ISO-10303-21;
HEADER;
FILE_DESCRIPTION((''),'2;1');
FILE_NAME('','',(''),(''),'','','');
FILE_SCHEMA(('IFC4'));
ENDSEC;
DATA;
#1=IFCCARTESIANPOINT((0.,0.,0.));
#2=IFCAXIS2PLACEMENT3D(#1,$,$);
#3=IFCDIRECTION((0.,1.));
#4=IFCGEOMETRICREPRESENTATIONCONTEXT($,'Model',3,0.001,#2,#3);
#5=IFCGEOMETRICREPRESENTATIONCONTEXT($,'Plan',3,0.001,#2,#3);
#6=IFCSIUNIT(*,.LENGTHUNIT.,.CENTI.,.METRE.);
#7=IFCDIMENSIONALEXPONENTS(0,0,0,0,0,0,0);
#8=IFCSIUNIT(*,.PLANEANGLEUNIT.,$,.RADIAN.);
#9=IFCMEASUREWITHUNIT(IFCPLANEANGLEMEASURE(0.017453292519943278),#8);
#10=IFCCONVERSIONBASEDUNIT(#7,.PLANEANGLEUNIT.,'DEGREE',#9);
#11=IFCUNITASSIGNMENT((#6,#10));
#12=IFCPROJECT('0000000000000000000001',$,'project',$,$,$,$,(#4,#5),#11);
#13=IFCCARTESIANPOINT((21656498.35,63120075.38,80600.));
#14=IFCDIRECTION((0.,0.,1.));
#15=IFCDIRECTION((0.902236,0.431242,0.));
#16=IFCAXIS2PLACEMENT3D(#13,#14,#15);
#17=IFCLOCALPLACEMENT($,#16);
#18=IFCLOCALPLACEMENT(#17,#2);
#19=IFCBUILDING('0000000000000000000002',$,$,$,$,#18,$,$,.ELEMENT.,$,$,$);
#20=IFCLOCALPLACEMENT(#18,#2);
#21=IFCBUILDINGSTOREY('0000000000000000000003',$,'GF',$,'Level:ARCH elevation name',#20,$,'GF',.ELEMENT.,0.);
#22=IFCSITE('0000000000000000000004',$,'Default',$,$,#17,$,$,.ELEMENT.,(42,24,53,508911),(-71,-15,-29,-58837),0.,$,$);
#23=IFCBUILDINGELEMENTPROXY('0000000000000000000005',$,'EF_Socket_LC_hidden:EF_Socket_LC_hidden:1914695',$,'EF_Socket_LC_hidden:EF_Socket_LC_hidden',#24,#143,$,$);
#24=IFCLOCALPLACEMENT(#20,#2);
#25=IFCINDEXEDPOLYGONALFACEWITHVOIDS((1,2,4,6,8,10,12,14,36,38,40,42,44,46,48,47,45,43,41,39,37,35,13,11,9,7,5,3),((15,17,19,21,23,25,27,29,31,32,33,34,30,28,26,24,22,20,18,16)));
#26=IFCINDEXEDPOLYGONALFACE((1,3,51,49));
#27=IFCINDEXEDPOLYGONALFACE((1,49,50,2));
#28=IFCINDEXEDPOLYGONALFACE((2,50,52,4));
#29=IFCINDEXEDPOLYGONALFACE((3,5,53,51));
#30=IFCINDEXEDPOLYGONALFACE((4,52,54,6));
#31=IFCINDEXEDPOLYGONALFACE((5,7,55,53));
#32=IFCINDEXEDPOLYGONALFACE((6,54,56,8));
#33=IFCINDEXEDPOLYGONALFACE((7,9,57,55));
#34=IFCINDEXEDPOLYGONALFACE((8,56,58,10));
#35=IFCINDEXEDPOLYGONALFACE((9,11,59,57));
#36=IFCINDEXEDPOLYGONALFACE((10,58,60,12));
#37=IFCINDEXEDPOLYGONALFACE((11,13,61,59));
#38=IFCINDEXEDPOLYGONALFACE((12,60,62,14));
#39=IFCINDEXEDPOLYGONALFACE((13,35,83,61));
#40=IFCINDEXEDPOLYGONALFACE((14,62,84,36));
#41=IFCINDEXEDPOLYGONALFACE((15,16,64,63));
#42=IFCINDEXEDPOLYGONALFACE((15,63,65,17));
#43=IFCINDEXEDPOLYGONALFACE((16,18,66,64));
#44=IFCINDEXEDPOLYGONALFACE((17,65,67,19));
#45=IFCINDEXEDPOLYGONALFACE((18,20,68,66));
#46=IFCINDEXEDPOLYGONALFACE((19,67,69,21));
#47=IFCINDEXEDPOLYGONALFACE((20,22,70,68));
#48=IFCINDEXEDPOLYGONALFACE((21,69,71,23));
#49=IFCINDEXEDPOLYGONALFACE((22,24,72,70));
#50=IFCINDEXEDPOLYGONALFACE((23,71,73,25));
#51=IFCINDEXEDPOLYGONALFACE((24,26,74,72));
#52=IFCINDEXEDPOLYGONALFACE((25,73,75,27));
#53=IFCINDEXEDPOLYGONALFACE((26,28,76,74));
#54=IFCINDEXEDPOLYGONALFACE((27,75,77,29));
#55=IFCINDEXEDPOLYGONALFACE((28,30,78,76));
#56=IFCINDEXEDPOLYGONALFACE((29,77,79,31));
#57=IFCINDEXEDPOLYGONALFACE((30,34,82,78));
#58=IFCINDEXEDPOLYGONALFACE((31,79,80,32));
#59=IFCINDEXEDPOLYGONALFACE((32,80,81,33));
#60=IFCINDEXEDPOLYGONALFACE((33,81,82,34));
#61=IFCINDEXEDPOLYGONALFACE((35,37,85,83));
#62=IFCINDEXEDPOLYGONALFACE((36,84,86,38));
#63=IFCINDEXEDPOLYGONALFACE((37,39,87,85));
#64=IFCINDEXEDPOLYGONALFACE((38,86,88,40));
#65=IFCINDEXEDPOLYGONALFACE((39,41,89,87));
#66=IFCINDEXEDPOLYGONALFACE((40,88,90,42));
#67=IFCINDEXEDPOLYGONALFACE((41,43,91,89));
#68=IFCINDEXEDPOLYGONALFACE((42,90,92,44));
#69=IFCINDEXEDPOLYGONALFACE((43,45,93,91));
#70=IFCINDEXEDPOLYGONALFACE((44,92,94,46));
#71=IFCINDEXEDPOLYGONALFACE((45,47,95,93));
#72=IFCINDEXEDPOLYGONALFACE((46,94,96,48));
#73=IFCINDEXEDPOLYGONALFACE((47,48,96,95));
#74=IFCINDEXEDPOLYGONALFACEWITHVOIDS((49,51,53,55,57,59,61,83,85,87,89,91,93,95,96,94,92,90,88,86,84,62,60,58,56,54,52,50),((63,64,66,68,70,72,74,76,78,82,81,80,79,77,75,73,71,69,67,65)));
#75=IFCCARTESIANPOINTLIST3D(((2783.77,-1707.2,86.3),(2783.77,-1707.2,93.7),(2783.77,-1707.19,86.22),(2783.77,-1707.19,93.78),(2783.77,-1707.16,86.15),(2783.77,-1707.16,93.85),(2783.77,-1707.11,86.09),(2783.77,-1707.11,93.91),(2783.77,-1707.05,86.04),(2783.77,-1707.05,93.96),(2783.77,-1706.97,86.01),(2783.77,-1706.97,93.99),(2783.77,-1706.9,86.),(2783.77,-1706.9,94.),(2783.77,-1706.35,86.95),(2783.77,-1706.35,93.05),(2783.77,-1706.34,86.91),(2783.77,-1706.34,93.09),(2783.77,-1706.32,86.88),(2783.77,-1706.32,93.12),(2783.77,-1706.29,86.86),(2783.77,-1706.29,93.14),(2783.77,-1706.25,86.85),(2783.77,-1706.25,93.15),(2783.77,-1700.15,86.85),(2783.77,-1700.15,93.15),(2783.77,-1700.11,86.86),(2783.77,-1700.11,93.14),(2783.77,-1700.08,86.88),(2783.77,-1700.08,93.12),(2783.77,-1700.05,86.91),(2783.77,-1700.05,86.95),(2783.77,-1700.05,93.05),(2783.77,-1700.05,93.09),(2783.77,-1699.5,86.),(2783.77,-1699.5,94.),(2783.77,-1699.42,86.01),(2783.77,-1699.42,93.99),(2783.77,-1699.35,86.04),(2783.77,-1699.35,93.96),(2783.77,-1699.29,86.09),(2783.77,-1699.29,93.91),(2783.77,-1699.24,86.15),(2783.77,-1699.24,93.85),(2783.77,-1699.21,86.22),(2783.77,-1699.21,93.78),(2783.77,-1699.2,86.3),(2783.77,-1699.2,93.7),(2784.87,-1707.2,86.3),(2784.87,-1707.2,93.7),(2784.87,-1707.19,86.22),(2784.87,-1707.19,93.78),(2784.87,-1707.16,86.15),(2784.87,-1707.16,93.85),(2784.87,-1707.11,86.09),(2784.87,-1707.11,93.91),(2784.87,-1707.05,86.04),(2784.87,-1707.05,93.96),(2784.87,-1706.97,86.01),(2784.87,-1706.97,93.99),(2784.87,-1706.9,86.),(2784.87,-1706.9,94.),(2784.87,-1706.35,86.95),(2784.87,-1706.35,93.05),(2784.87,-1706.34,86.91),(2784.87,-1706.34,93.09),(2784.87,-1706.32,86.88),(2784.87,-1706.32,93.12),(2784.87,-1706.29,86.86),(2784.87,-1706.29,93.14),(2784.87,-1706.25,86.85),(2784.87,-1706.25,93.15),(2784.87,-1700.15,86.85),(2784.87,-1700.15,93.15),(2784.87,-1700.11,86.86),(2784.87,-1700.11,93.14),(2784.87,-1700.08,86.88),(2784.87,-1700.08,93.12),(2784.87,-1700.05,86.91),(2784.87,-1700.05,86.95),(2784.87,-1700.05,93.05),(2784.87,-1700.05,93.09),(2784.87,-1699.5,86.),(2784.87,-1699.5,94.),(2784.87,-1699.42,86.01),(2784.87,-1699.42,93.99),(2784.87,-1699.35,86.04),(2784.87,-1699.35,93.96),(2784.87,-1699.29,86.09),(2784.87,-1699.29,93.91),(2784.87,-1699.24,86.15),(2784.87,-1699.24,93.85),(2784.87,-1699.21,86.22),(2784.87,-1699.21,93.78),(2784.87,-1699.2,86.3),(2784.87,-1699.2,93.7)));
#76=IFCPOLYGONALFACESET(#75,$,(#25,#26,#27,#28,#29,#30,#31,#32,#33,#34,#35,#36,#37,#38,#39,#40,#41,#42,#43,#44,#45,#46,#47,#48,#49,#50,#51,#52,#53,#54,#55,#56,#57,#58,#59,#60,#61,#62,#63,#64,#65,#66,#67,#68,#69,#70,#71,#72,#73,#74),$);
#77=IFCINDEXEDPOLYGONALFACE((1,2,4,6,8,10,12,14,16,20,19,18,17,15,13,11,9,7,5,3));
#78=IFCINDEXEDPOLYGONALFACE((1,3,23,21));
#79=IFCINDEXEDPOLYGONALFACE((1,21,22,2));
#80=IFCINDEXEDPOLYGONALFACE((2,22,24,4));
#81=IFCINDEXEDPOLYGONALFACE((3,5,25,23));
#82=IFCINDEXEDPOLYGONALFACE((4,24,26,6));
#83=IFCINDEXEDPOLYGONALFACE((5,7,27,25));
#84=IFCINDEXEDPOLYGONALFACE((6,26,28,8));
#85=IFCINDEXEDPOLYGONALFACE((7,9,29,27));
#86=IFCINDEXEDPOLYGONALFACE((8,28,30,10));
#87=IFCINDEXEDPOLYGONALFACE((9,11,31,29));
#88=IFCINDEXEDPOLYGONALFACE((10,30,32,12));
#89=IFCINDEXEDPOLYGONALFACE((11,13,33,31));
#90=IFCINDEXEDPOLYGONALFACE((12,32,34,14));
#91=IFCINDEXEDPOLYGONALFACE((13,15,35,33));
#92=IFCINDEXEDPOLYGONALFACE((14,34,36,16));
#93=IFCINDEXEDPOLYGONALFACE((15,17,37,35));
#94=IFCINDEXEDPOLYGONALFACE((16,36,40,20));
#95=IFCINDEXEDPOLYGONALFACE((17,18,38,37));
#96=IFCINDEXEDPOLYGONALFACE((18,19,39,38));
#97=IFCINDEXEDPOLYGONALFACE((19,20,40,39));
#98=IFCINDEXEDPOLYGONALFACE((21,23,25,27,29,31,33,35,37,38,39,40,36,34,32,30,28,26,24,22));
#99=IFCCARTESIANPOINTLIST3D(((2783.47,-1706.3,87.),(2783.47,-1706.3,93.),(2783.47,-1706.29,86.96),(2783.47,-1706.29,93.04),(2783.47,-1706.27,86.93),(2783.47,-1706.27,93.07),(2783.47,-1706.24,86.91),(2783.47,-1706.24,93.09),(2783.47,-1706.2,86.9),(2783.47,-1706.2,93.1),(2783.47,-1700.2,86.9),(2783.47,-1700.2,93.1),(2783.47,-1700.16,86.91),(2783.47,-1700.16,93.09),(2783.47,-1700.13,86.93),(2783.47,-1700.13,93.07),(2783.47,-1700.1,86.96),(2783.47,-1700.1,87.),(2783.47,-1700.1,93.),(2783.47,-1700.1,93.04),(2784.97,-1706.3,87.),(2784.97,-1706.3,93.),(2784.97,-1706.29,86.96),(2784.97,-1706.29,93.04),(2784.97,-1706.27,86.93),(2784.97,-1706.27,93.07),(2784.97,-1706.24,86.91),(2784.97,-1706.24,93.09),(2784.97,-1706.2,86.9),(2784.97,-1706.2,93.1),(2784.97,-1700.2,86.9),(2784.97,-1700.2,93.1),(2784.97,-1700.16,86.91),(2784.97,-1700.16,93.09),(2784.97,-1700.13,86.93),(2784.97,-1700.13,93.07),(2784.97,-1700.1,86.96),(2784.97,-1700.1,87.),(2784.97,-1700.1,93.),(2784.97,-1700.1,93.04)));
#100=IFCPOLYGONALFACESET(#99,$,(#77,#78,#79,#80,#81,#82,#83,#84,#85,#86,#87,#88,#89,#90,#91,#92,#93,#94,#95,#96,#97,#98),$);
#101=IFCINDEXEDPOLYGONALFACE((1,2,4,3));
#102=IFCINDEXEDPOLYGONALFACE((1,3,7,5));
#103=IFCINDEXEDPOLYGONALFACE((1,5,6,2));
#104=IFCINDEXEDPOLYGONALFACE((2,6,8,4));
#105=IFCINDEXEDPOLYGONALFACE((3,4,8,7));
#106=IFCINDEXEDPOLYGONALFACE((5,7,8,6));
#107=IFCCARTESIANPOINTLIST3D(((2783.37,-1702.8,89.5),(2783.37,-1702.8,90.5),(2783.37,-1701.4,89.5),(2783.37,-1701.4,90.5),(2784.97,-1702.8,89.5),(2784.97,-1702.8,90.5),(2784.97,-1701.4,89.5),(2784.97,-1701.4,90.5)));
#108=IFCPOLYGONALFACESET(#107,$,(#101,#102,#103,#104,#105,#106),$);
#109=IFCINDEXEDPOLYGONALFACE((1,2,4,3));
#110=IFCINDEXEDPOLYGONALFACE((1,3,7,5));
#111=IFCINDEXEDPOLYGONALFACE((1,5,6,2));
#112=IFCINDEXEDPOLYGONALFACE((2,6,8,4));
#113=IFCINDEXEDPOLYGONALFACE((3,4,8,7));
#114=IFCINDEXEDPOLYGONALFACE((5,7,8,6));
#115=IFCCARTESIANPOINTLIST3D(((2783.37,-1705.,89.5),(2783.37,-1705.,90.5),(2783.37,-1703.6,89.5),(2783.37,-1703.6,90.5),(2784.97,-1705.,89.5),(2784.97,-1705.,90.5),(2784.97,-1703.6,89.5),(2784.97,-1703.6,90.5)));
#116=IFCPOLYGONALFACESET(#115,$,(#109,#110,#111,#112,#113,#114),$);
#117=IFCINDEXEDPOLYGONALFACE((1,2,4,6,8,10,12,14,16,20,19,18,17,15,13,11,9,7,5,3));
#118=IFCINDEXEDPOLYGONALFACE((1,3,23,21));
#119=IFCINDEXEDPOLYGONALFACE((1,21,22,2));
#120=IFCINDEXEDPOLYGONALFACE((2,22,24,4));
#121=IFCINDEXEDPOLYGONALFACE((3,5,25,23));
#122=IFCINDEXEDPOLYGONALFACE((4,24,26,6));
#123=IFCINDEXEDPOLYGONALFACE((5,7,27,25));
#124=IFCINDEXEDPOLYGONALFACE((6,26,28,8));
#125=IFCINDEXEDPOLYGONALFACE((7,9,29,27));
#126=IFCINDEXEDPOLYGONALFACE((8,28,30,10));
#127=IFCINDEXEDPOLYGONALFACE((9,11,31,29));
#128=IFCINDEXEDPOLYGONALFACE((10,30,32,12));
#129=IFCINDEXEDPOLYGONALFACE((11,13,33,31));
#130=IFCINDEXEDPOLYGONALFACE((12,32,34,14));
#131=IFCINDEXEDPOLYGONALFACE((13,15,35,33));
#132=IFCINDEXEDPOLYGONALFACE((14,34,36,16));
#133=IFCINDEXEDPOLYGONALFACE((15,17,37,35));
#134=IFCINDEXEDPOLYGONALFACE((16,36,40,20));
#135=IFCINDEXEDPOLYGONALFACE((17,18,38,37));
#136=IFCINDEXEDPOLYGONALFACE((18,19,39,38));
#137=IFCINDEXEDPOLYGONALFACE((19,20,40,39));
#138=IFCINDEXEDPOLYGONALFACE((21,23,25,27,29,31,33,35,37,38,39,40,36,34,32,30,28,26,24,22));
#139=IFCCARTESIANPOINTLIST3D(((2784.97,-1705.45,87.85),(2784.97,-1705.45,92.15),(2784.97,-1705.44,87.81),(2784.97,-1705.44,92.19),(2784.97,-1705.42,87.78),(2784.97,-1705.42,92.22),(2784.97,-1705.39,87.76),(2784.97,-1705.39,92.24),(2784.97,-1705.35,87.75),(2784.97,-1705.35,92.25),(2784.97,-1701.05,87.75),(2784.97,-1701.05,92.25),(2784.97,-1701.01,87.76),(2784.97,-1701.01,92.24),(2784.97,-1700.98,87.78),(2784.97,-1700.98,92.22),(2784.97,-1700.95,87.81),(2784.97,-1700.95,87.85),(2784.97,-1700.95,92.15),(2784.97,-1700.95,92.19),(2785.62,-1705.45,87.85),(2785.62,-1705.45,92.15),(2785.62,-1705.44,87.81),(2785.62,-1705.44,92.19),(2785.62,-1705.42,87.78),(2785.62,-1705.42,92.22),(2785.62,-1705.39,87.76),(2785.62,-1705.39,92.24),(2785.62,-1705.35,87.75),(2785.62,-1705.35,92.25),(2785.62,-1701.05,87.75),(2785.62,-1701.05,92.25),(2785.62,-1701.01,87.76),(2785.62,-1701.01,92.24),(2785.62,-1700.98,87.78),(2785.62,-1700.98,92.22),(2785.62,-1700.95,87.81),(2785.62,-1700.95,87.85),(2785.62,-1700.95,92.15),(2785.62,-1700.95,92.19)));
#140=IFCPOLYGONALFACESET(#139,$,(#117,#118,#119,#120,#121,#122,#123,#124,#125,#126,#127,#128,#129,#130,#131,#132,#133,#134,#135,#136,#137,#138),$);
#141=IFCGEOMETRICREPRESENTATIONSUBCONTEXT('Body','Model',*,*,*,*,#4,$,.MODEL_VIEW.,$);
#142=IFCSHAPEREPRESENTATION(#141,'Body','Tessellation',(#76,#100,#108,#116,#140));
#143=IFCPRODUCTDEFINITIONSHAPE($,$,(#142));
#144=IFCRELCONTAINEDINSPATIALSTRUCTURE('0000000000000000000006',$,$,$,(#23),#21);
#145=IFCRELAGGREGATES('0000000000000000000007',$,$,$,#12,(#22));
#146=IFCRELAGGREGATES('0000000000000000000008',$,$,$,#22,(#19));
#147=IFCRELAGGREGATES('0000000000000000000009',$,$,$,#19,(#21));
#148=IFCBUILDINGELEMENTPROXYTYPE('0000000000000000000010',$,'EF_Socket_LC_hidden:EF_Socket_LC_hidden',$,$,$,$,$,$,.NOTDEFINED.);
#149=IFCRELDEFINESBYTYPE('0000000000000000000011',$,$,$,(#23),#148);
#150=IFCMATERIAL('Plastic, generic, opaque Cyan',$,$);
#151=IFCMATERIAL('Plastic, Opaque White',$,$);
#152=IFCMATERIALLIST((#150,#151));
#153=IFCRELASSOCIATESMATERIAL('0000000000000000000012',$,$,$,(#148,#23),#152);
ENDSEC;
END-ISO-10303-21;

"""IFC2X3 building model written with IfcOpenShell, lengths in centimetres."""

from ifc_helpers import new_model, entity, si_unit, converted_unit, direction, frame, frame_2d, origin, place, context, subcontext, project, spatial, polyline, circle_curve, parameter, trimmed, segment, composite_curve, rectangle, outline, extrude, source, transform, mapped, material, material_list, type_object, type_shapes, element, save


model = new_model("IFC2X3")

# Units and contexts
model_context = context("Model", 3, precision=0.001, world=origin(), true_north=direction((0.0, 1.0)))
plan_context = context("Plan", 3, precision=0.001, world=origin(), true_north=direction((0.0, 1.0)))
body_context = subcontext(model_context, "Body", "Model", "MODEL_VIEW")
ifc_project = project(units=[si_unit("LENGTHUNIT", "METRE", prefix="CENTI"), converted_unit("PLANEANGLEUNIT", "DEGREE", entity("IfcPlaneAngleMeasure", 0.017453292519943278), si_unit("PLANEANGLEUNIT", "RADIAN"), dimensions=[0, 0, 0, 0, 0, 0, 0])], contexts=[model_context, plan_context])

# Site, building, storey
site_placement = place(None, frame((21656498.35, 63120075.38, 80600.0), z_axis=(0.0, 0.0, 1.0), x_axis=(0.902236, 0.431242, 0.0)))
site = spatial("IfcSite", under=ifc_project, at=site_placement, Name="Default", CompositionType="ELEMENT", RefLatitude=(42, 24, 53, 508911), RefLongitude=(-71, -15, -29, -58837), RefElevation=0.0)
building_placement = place(site_placement, origin())
building = spatial("IfcBuilding", under=site, at=building_placement, CompositionType="ELEMENT")
storey_placement = place(building_placement, origin())
storey = spatial("IfcBuildingStorey", under=building, at=storey_placement, Name="GF", ObjectType="Level:ARCH elevation name", LongName="GF", CompositionType="ELEMENT", Elevation=0.0)

# Building element proxy
ifc_material_1 = material(Name="Plastic, generic, opaque Cyan")
ifc_material_2 = material(Name="Plastic, Opaque White")
ifc_material_list_1 = material_list([ifc_material_1, ifc_material_2])
building_element_proxy_type_1 = type_object("IfcBuildingElementProxyType", Name="EF_Socket_LC_hidden:EF_Socket_LC_hidden", PredefinedType="NOTDEFINED", material=ifc_material_list_1)
shared_shape_1 = source(origin(), body_context, "Body", "SweptSolid", [
    extrude(outline(composite_curve([segment(trimmed(circle_curve(frame_2d((3.7, -3.7), x_axis=(1.0, 0.0)), 0.3), [parameter(270.0)], [parameter(0.0)], True, "PARAMETER"), True, "CONTINUOUS"), segment(polyline([(4.0, -3.7), (4.0, 3.7)]), True, "CONTINUOUS"), segment(trimmed(circle_curve(frame_2d((3.7, 3.7), x_axis=(1.0, 0.0)), 0.3), [parameter(0.0)], [parameter(90.0)], True, "PARAMETER"), True, "CONTINUOUS"), segment(polyline([(3.7, 4.0), (-3.7, 4.0)]), True, "CONTINUOUS"), segment(trimmed(circle_curve(frame_2d((-3.7, 3.7), x_axis=(1.0, 0.0)), 0.3), [parameter(90.0)], [parameter(180.0)], True, "PARAMETER"), True, "CONTINUOUS"), segment(polyline([(-4.0, 3.7), (-4.0, -3.7)]), True, "CONTINUOUS"), segment(trimmed(circle_curve(frame_2d((-3.7, -3.7), x_axis=(1.0, 0.0)), 0.3), [parameter(180.0)], [parameter(270.0)], True, "PARAMETER"), True, "CONTINUOUS"), segment(polyline([(-3.7, -4.0), (3.7, -4.0)]), True, "CONTINUOUS")], self_intersect=False), holes=[composite_curve([segment(polyline([(-3.15, -3.05), (-3.15, 3.05)]), True, "CONTINUOUS"), segment(trimmed(circle_curve(frame_2d((-3.05, 3.05), x_axis=(1.0, 0.0)), 0.1), [parameter(90.0)], [parameter(180.0)], True, "PARAMETER"), False, "CONTINUOUS"), segment(polyline([(-3.05, 3.15), (3.05, 3.15)]), True, "CONTINUOUS"), segment(trimmed(circle_curve(frame_2d((3.05, 3.05), x_axis=(1.0, 0.0)), 0.1), [parameter(360.0)], [parameter(90.0)], True, "PARAMETER"), False, "CONTINUOUS"), segment(polyline([(3.15, 3.05), (3.15, -3.05)]), True, "CONTINUOUS"), segment(trimmed(circle_curve(frame_2d((3.05, -3.05), x_axis=(1.0, 0.0)), 0.1), [parameter(270.0)], [parameter(360.0)], True, "PARAMETER"), False, "CONTINUOUS"), segment(polyline([(3.05, -3.15), (-3.05, -3.15)]), True, "CONTINUOUS"), segment(trimmed(circle_curve(frame_2d((-3.05, -3.05), x_axis=(1.0, 0.0)), 0.1), [parameter(180.0)], [parameter(270.0)], True, "PARAMETER"), False, "CONTINUOUS")], self_intersect=False)]), frame((0.0, 0.0, 0.0), z_axis=(0.0, 1.0, 0.0), x_axis=(1.0, 0.0, 0.0)), (0.0, 0.0, 1.0), 1.1),
    extrude(outline(composite_curve([segment(trimmed(circle_curve(frame_2d((3.0, -3.0), x_axis=(1.0, 0.0)), 0.1), [parameter(270.0)], [parameter(0.0)], True, "PARAMETER"), True, "CONTINUOUS"), segment(polyline([(3.1, -3.0), (3.1, 3.0)]), True, "CONTINUOUS"), segment(trimmed(circle_curve(frame_2d((3.0, 3.0), x_axis=(1.0, 0.0)), 0.1), [parameter(0.0)], [parameter(90.0)], True, "PARAMETER"), True, "CONTINUOUS"), segment(polyline([(3.0, 3.1), (-3.0, 3.1)]), True, "CONTINUOUS"), segment(trimmed(circle_curve(frame_2d((-3.0, 3.0), x_axis=(1.0, 0.0)), 0.1), [parameter(90.0)], [parameter(180.0)], True, "PARAMETER"), True, "CONTINUOUS"), segment(polyline([(-3.1, 3.0), (-3.1, -3.0)]), True, "CONTINUOUS"), segment(trimmed(circle_curve(frame_2d((-3.0, -3.0), x_axis=(1.0, 0.0)), 0.1), [parameter(180.0)], [parameter(270.0)], True, "PARAMETER"), True, "CONTINUOUS"), segment(polyline([(-3.0, -3.1), (3.0, -3.1)]), True, "CONTINUOUS")], self_intersect=False)), frame((0.0, -0.1, 0.0), z_axis=(0.0, 1.0, 0.0), x_axis=(1.0, 0.0, 0.0)), (0.0, 0.0, 1.0), 1.5),
    extrude(rectangle(XDim=1.6, YDim=1.4, at=frame_2d((0.0, 0.0), x_axis=(1.0, 0.0))), frame((1.1, 0.7, -0.5), z_axis=(0.0, 0.0, 1.0), x_axis=(0.0, -1.0, 0.0)), (0.0, 0.0, 1.0), 1.0),
    extrude(rectangle(XDim=1.6, YDim=1.4, at=frame_2d((0.0, 0.0), x_axis=(1.0, 0.0))), frame((-1.1, 0.7, -0.5), z_axis=(0.0, 0.0, 1.0), x_axis=(0.0, -1.0, 0.0)), (0.0, 0.0, 1.0), 1.0),
    extrude(outline(composite_curve([segment(trimmed(circle_curve(frame_2d((2.15, -2.15), x_axis=(1.0, 0.0)), 0.1), [parameter(270.0)], [parameter(0.0)], True, "PARAMETER"), True, "CONTINUOUS"), segment(polyline([(2.25, -2.15), (2.25, 2.15)]), True, "CONTINUOUS"), segment(trimmed(circle_curve(frame_2d((2.15, 2.15), x_axis=(1.0, 0.0)), 0.1), [parameter(0.0)], [parameter(90.0)], True, "PARAMETER"), True, "CONTINUOUS"), segment(polyline([(2.15, 2.25), (-2.15, 2.25)]), True, "CONTINUOUS"), segment(trimmed(circle_curve(frame_2d((-2.15, 2.15), x_axis=(1.0, 0.0)), 0.1), [parameter(90.0)], [parameter(180.0)], True, "PARAMETER"), True, "CONTINUOUS"), segment(polyline([(-2.25, 2.15), (-2.25, -2.15)]), True, "CONTINUOUS"), segment(trimmed(circle_curve(frame_2d((-2.15, -2.15), x_axis=(1.0, 0.0)), 0.1), [parameter(180.0)], [parameter(270.0)], True, "PARAMETER"), True, "CONTINUOUS"), segment(polyline([(-2.15, -2.25), (2.15, -2.25)]), True, "CONTINUOUS")], self_intersect=False)), frame((0.0, -0.75, 0.0), z_axis=(0.0, 1.0, 0.0), x_axis=(1.0, 0.0, 0.0)), (0.0, 0.0, 1.0), 0.65),
])
type_shapes(building_element_proxy_type_1, [shared_shape_1])
proxy_1_placement = place(storey_placement, frame((2784.87, -1703.2, 90.0), z_axis=(0.0, 0.0, 1.0), x_axis=(0.0, 1.0, 0.0)))
element("IfcBuildingElementProxy", 1, at=proxy_1_placement, inside=storey, type_object=building_element_proxy_type_1, material=ifc_material_list_1, Name="EF_Socket_LC_hidden:EF_Socket_LC_hidden:1914695", ObjectType="EF_Socket_LC_hidden:EF_Socket_LC_hidden", context=body_context, shape_type="MappedRepresentation", body=[
    mapped(shared_shape_1, transform((0.0, 0.0, 0.0), scale=1.0)),
])

save(model, "model.ifc")
